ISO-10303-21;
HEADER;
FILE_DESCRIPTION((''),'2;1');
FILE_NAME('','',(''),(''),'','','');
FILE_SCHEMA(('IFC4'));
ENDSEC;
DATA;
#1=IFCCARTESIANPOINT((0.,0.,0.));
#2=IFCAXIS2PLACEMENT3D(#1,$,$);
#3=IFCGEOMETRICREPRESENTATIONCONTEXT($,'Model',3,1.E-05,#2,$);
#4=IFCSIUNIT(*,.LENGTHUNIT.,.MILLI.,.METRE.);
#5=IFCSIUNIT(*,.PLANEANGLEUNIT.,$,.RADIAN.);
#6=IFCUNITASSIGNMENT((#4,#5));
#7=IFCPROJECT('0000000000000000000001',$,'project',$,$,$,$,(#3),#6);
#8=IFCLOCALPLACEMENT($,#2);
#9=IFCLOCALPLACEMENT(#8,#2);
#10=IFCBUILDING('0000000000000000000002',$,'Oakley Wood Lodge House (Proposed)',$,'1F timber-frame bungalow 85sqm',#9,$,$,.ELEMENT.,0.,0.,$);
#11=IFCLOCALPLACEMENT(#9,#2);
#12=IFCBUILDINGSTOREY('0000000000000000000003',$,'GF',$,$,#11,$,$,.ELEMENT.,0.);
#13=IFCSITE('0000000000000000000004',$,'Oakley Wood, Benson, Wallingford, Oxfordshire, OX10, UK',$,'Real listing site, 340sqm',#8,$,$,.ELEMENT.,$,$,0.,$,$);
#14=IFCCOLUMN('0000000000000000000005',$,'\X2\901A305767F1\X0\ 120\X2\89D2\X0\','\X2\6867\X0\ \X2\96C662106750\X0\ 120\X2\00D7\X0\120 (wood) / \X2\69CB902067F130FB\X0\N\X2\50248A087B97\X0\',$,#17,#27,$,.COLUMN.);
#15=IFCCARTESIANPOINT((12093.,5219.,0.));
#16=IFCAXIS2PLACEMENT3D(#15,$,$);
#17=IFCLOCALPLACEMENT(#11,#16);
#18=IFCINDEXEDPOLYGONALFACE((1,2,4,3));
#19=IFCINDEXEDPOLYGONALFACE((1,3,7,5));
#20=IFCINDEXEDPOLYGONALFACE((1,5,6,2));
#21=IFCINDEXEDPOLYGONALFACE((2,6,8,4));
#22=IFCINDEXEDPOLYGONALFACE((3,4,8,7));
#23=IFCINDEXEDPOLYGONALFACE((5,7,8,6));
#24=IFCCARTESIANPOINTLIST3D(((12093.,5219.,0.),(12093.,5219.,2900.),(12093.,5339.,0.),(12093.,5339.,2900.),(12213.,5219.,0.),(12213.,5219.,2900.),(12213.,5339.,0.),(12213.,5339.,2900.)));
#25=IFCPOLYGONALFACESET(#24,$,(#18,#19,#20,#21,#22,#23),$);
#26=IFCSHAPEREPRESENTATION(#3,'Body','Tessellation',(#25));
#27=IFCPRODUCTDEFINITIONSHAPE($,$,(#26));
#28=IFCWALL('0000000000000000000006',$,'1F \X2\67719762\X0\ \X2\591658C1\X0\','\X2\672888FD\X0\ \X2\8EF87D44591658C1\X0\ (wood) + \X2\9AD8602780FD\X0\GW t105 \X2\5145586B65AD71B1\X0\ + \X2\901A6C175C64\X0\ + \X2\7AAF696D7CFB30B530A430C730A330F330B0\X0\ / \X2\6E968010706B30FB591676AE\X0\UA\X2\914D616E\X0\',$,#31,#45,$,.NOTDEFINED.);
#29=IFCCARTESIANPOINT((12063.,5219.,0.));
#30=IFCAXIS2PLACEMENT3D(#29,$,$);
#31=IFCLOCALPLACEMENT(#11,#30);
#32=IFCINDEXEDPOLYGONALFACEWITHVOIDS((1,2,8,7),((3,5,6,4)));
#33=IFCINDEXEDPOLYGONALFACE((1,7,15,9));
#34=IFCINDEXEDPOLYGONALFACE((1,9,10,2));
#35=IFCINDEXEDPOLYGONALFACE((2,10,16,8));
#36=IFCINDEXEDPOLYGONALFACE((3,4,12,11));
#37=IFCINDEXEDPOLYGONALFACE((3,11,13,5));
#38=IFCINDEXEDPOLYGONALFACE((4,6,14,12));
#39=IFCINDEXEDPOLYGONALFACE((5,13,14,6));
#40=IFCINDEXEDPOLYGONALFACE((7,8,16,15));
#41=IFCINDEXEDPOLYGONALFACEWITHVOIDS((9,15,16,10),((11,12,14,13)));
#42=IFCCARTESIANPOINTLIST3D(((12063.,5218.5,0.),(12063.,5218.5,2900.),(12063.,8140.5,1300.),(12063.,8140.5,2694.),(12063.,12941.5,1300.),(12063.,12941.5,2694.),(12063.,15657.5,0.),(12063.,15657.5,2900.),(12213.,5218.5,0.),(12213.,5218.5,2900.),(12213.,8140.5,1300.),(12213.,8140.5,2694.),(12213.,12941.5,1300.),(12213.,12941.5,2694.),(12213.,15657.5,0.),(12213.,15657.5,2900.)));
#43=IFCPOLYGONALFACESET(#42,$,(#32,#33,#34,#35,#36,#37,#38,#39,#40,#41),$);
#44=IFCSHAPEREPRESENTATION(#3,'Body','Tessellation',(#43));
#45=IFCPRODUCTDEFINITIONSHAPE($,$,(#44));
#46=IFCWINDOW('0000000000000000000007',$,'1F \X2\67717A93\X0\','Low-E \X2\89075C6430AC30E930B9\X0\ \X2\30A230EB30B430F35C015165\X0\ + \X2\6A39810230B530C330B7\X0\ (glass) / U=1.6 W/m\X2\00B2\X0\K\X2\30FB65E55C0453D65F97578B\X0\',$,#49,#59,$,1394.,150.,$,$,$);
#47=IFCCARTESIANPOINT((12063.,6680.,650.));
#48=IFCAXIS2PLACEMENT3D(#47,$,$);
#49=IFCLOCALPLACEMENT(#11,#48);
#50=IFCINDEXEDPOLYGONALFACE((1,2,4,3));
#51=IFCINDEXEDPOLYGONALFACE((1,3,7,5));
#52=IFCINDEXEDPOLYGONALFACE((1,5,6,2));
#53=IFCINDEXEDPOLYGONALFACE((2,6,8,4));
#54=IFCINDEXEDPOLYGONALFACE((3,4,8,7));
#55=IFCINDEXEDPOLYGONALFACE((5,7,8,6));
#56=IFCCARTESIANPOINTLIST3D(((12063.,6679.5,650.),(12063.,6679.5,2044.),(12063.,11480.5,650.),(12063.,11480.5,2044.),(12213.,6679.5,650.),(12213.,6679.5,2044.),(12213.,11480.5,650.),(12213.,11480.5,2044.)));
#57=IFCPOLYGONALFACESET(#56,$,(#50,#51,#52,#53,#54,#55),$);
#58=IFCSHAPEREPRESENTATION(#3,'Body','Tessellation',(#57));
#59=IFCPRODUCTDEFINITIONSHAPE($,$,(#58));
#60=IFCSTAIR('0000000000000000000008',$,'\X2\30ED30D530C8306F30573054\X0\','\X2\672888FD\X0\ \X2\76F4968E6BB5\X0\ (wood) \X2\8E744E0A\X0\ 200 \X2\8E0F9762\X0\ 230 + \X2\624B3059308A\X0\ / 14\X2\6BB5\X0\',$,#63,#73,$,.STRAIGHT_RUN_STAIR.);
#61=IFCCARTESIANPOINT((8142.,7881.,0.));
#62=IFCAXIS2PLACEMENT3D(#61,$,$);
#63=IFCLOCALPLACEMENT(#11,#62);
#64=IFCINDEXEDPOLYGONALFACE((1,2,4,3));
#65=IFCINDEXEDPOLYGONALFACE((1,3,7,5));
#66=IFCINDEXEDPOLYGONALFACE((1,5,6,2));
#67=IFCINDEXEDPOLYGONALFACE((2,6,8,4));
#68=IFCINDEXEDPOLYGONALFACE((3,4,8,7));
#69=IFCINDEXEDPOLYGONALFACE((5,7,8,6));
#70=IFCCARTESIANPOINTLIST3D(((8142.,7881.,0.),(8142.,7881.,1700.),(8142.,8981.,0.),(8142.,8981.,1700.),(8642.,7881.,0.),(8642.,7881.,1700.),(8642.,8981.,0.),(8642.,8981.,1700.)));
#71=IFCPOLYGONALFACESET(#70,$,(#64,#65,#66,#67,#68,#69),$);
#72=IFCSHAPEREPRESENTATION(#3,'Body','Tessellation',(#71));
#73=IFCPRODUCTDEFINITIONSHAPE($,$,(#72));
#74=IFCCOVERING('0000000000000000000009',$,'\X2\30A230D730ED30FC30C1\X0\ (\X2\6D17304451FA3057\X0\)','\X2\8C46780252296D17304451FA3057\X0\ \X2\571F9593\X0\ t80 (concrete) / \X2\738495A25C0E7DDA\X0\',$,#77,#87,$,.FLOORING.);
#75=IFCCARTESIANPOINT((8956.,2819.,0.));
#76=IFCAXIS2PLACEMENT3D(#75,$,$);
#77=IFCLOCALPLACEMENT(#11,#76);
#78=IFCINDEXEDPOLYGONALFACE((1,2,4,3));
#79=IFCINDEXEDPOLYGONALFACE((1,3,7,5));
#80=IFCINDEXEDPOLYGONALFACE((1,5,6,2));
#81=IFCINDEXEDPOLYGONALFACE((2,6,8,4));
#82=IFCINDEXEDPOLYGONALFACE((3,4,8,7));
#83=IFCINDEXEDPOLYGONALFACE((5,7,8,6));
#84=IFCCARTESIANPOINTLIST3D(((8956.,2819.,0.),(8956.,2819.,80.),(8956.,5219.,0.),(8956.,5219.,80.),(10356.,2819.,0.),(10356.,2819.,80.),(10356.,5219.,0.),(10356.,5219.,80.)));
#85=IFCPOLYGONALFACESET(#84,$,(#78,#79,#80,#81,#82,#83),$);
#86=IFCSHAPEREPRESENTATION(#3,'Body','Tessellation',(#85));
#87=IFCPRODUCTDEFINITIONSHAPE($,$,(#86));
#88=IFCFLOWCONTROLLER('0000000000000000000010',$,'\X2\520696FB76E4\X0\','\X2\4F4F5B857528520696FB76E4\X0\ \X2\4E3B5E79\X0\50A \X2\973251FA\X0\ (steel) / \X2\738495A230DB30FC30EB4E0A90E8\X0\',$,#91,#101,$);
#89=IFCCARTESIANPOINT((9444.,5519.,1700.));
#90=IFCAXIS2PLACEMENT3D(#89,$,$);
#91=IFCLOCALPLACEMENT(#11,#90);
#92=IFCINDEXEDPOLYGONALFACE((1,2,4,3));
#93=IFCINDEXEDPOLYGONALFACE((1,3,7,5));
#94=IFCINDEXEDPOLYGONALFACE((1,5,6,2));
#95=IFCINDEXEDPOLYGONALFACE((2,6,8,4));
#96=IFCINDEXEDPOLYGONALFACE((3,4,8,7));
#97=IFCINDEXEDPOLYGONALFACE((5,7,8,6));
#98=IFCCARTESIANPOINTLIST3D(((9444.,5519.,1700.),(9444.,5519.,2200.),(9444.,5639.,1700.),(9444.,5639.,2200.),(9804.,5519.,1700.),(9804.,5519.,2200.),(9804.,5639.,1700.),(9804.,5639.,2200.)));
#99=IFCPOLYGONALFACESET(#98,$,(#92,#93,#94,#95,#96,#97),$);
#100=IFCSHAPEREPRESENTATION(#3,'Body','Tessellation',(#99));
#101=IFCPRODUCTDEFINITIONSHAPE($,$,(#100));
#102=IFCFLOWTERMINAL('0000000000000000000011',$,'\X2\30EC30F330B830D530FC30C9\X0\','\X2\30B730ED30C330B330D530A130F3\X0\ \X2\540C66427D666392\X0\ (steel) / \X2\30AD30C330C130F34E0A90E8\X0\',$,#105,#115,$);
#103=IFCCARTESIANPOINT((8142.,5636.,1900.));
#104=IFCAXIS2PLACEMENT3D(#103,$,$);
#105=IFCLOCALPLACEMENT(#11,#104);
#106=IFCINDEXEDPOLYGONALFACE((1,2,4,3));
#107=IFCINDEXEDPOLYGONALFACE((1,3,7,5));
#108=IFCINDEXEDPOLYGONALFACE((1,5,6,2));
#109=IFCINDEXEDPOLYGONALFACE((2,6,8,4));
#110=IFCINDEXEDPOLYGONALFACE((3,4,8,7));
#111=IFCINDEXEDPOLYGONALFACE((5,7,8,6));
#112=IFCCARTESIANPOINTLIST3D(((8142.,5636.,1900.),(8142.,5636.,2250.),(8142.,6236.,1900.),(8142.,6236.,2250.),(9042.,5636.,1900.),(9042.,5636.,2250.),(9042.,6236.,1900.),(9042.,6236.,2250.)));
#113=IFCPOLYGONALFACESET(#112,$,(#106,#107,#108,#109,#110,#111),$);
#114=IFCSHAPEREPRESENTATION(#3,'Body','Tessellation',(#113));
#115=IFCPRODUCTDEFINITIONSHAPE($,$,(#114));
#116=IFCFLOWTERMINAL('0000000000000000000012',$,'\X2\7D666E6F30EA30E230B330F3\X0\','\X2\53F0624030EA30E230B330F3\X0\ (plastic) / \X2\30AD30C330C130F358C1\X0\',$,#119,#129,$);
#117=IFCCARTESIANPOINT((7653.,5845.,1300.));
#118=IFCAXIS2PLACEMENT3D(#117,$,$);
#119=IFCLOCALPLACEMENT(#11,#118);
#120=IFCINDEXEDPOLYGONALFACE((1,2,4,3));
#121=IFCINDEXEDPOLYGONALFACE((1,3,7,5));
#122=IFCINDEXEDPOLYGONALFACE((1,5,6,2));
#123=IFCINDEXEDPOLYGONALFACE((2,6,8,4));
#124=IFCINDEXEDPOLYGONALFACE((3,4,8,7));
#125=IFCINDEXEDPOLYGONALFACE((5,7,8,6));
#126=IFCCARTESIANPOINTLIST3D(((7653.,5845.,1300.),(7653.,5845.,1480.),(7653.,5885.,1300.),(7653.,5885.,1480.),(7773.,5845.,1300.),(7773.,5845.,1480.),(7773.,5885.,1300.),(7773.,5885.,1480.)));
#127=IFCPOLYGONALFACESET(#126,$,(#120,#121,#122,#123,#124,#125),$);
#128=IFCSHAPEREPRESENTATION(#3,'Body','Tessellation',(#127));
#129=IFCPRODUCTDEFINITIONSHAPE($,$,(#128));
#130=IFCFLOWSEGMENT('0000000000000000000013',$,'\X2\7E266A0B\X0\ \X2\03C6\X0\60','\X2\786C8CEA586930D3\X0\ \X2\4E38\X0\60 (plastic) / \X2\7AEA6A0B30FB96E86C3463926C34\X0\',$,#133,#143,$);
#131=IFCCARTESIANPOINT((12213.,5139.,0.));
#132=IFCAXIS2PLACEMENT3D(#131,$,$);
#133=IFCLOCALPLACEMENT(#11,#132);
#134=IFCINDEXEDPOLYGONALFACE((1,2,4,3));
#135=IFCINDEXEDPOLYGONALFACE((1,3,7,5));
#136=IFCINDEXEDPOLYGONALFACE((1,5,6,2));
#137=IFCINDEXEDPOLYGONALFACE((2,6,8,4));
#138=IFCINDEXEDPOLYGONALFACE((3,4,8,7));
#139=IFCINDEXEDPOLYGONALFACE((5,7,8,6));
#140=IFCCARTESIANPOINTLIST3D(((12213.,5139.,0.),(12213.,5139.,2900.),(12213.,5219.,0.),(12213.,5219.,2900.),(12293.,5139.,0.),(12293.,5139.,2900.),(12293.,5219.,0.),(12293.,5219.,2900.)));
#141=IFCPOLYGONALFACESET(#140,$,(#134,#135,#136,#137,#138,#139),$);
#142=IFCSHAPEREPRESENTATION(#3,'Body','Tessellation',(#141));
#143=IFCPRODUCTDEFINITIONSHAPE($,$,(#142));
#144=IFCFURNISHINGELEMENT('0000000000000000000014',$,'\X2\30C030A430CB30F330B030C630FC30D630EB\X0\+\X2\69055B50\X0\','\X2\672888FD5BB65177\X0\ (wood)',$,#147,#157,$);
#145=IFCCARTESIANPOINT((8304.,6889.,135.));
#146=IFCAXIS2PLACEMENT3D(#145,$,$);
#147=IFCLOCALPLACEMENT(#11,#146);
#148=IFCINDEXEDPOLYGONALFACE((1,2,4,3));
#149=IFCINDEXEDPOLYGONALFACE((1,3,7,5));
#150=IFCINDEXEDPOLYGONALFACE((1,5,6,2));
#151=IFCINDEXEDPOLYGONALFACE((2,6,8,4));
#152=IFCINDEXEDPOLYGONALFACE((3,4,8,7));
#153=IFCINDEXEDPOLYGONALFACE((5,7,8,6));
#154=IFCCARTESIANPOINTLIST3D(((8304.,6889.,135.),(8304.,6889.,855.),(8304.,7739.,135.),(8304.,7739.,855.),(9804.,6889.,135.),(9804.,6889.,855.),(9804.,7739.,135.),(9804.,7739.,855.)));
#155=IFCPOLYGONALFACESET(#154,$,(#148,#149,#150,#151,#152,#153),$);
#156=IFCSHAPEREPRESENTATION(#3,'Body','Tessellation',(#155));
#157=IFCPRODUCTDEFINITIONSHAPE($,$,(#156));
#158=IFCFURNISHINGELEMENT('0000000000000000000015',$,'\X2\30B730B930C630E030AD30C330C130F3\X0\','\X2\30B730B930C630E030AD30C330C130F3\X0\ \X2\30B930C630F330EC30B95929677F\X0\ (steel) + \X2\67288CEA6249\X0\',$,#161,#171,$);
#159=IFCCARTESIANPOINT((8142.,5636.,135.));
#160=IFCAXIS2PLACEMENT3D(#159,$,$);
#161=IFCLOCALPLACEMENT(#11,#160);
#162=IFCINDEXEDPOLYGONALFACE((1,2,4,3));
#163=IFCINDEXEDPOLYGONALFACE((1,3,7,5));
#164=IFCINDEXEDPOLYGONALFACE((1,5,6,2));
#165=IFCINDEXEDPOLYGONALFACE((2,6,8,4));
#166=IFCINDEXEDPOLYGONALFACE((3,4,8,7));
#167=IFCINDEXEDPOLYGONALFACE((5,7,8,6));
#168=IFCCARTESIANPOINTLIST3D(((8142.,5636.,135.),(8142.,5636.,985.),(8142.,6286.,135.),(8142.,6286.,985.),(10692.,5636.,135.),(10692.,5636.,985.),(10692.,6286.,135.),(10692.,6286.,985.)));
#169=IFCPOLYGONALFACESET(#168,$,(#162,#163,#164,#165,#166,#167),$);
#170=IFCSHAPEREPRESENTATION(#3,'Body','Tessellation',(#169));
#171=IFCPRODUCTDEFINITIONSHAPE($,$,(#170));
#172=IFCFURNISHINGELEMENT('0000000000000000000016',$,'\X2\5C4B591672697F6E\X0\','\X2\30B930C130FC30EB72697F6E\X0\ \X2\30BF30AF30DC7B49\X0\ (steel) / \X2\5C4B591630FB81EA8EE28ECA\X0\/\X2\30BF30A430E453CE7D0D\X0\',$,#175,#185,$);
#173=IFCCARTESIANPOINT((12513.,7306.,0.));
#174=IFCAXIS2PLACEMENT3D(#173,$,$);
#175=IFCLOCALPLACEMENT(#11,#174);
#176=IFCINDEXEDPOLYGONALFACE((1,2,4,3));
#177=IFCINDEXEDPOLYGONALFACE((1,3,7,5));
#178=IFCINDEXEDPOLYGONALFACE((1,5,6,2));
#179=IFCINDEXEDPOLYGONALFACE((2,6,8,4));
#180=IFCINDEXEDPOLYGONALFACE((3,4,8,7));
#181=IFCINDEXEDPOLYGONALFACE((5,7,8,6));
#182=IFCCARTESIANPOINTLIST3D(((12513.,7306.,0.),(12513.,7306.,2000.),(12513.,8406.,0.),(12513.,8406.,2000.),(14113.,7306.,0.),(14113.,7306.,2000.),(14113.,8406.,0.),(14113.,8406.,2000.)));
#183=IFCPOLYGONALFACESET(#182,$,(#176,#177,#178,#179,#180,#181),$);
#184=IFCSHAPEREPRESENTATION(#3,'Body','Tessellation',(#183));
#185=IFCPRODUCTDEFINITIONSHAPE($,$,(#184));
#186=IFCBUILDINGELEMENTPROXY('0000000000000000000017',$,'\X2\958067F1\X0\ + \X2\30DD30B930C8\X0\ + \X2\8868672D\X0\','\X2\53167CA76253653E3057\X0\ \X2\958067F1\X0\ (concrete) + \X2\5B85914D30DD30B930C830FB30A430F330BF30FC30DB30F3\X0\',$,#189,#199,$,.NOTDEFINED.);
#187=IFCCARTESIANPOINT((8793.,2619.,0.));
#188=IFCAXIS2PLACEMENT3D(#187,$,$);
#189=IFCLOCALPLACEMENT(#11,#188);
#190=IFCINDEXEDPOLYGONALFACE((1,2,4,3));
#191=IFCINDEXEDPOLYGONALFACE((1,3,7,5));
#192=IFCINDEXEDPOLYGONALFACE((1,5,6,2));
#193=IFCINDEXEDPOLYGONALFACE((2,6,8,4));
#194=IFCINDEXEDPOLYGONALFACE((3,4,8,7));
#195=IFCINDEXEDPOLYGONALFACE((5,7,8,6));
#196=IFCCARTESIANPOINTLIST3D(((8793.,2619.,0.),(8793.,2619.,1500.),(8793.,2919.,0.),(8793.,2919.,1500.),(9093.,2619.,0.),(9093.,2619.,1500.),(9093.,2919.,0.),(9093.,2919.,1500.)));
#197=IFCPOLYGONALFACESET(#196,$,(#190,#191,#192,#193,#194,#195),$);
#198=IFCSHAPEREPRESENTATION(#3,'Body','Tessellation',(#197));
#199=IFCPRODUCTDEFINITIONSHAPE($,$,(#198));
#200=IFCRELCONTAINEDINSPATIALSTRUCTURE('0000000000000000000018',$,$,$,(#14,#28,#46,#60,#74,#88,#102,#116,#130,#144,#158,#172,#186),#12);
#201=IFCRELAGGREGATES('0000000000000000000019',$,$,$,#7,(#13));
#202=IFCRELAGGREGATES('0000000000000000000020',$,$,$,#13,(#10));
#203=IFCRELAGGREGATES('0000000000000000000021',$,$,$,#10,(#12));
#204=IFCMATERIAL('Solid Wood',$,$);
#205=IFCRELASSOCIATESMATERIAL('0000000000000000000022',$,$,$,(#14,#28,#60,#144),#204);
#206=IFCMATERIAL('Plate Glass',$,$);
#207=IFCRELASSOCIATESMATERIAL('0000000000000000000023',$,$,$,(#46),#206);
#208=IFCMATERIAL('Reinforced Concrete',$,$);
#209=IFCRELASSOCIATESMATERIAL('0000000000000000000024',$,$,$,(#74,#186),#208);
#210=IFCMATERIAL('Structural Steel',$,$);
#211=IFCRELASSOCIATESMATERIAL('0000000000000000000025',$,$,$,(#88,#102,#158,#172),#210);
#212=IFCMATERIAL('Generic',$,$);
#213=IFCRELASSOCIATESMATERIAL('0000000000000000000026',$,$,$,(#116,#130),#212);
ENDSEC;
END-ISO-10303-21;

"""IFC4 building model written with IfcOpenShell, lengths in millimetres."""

from ifc_helpers import new_model, si_unit, frame, frame_2d, origin, place, context, project, spatial, rectangle, extrude, material, element, fill, save


model = new_model("IFC4")

# Units and contexts
model_context = context("Model", 3, precision=1e-05, world=origin())
ifc_project = project(units=[si_unit("LENGTHUNIT", "METRE", prefix="MILLI"), si_unit("PLANEANGLEUNIT", "RADIAN")], contexts=[model_context])

# Site, building, storey
site_placement = place(None, origin())
site = spatial("IfcSite", under=ifc_project, at=site_placement, Name="Oakley Wood, Benson, Wallingford, Oxfordshire, OX10, UK", ObjectType="Real listing site, 340sqm", CompositionType="ELEMENT", RefElevation=0.0)
building_placement = place(site_placement, origin())
building = spatial("IfcBuilding", under=site, at=building_placement, Name="Oakley Wood Lodge House (Proposed)", ObjectType="1F timber-frame bungalow 85sqm", CompositionType="ELEMENT", ElevationOfRefHeight=0.0, ElevationOfTerrain=0.0)
storey_placement = place(building_placement, origin())
storey = spatial("IfcBuildingStorey", under=building, at=storey_placement, Name="GF", CompositionType="ELEMENT", Elevation=0.0)

# Column
ifc_material_1 = material(Name="Solid Wood")
column_1_placement = place(storey_placement, frame((12093.0, 5219.0, 0.0)))
element("IfcColumn", 1, at=column_1_placement, inside=storey, material=ifc_material_1, Name="通し柱 120角", Description="桧 集成材 120×120 (wood) / 構造柱・N値計算", PredefinedType="COLUMN", context=model_context, shape_type="SweptSolid", body=[
    extrude(rectangle(XDim=120.0, YDim=120.0, at=frame_2d((60.0, 60.0))), frame((12093.0, 5219.0, 0.0)), (0.0, 0.0, 1.0), 2900.0),
])

# Wall, opening, window
wall_1_placement = place(storey_placement, frame((12063.0, 5219.0, 0.0)))
wall_1 = element("IfcWall", 2, at=wall_1_placement, inside=storey, material=ifc_material_1, Name="1F 東面 外壁", Description="木製 軸組外壁 (wood) + 高性能GW t105 充填断熱 + 通気層 + 窯業系サイディング / 準耐火・外皮UA配慮", PredefinedType="NOTDEFINED", context=model_context, shape_type="SweptSolid", body=[
    extrude(rectangle(XDim=150.0, YDim=10439.0, at=frame_2d((75.0, 5219.0))), frame((12063.0, 5219.0, 0.0)), (0.0, 0.0, 1.0), 2900.0),
])
opening_placement = place(storey_placement, frame((12063.0, 6680.0, 650.0)))
opening = element("IfcOpeningElement", 3, at=opening_placement, cuts=wall_1, PredefinedType="NOTDEFINED", context=model_context, shape_type="SweptSolid", body=[
    extrude(rectangle(XDim=150.0, YDim=4801.0, at=frame_2d((75.0, 2400.0))), frame((12063.0, 6680.0, 650.0)), (0.0, 0.0, 1.0), 1394.0),
])
ifc_material_2 = material(Name="Plate Glass")
window_placement = place(storey_placement, frame((12063.0, 6680.0, 650.0)))
window = element("IfcWindow", 4, at=window_placement, inside=storey, material=ifc_material_2, Name="1F 東窓", Description="Low-E 複層ガラス アルゴン封入 + 樹脂サッシ (glass) / U=1.6 W/m²K・日射取得型", OverallHeight=1394.0, OverallWidth=150.0, context=model_context, shape_type="SweptSolid", body=[
    extrude(rectangle(XDim=150.0, YDim=4801.0, at=frame_2d((75.0, 2400.0))), frame((12063.0, 6680.0, 650.0)), (0.0, 0.0, 1.0), 1394.0),
])
fill(opening, window)

# Stair
stair_placement = place(storey_placement, frame((8142.0, 7881.0, 0.0)))
element("IfcStair", 5, at=stair_placement, inside=storey, material=ifc_material_1, Name="ロフトはしご", Description="木製 直階段 (wood) 蹴上 200 踏面 230 + 手すり / 14段", PredefinedType="STRAIGHT_RUN_STAIR", context=model_context, shape_type="SweptSolid", body=[
    extrude(rectangle(XDim=500.0, YDim=1100.0, at=frame_2d((250.0, 550.0))), frame((8142.0, 7881.0, 0.0)), (0.0, 0.0, 1.0), 1700.0),
])

# Covering
ifc_material_3 = material(Name="Reinforced Concrete")
covering_placement = place(storey_placement, frame((8956.0, 2819.0, 0.0)))
element("IfcCovering", 6, at=covering_placement, inside=storey, material=ifc_material_3, Name="アプローチ (洗い出し)", Description="豆砂利洗い出し 土間 t80 (concrete) / 玄関導線", PredefinedType="FLOORING", context=model_context, shape_type="SweptSolid", body=[
    extrude(rectangle(XDim=1400.0, YDim=2400.0, at=frame_2d((700.0, 1200.0))), frame((8956.0, 2819.0, 0.0)), (0.0, 0.0, 1.0), 80.0),
])

# Flow controller
ifc_material_4 = material(Name="Structural Steel")
flow_controller_placement = place(storey_placement, frame((9444.0, 5519.0, 1700.0)))
element("IfcFlowController", 7, at=flow_controller_placement, inside=storey, material=ifc_material_4, Name="分電盤", Description="住宅用分電盤 主幹50A 露出 (steel) / 玄関ホール上部", context=model_context, shape_type="SweptSolid", body=[
    extrude(rectangle(XDim=360.0, YDim=120.0, at=frame_2d((180.0, 60.0))), frame((9444.0, 5519.0, 1700.0)), (0.0, 0.0, 1.0), 500.0),
])

# Flow terminals
flow_terminal_1_placement = place(storey_placement, frame((8142.0, 5636.0, 1900.0)))
element("IfcFlowTerminal", 8, at=flow_terminal_1_placement, inside=storey, material=ifc_material_4, Name="レンジフード", Description="シロッコファン 同時給排 (steel) / キッチン上部", context=model_context, shape_type="SweptSolid", body=[
    extrude(rectangle(XDim=900.0, YDim=600.0, at=frame_2d((450.0, 300.0))), frame((8142.0, 5636.0, 1900.0)), (0.0, 0.0, 1.0), 350.0),
])
ifc_material_5 = material(Name="Generic")
flow_terminal_2_placement = place(storey_placement, frame((7653.0, 5845.0, 1300.0)))
element("IfcFlowTerminal", 9, at=flow_terminal_2_placement, inside=storey, material=ifc_material_5, Name="給湯リモコン", Description="台所リモコン (plastic) / キッチン壁", context=model_context, shape_type="SweptSolid", body=[
    extrude(rectangle(XDim=120.0, YDim=40.0, at=frame_2d((60.0, 20.0))), frame((7653.0, 5845.0, 1300.0)), (0.0, 0.0, 1.0), 180.0),
])

# Flow segment
flow_segment_placement = place(storey_placement, frame((12213.0, 5139.0, 0.0)))
element("IfcFlowSegment", 10, at=flow_segment_placement, inside=storey, material=ifc_material_5, Name="縦樋 φ60", Description="硬質塩ビ 丸60 (plastic) / 竪樋・雨水排水", context=model_context, shape_type="SweptSolid", body=[
    extrude(rectangle(XDim=80.0, YDim=80.0, at=frame_2d((40.0, 40.0))), frame((12213.0, 5139.0, 0.0)), (0.0, 0.0, 1.0), 2900.0),
])

# Furnishing elements
furnishing_1_placement = place(storey_placement, frame((8304.0, 6889.0, 135.0)))
element("IfcFurnishingElement", 11, at=furnishing_1_placement, inside=storey, material=ifc_material_1, Name="ダイニングテーブル+椅子", Description="木製家具 (wood)", context=model_context, shape_type="SweptSolid", body=[
    extrude(rectangle(XDim=1500.0, YDim=850.0, at=frame_2d((750.0, 425.0))), frame((8304.0, 6889.0, 135.0)), (0.0, 0.0, 1.0), 720.0),
])
furnishing_2_placement = place(storey_placement, frame((8142.0, 5636.0, 135.0)))
element("IfcFurnishingElement", 12, at=furnishing_2_placement, inside=storey, material=ifc_material_4, Name="システムキッチン", Description="システムキッチン ステンレス天板 (steel) + 木質扉", context=model_context, shape_type="SweptSolid", body=[
    extrude(rectangle(XDim=2550.0, YDim=650.0, at=frame_2d((1275.0, 325.0))), frame((8142.0, 5636.0, 135.0)), (0.0, 0.0, 1.0), 850.0),
])
furnishing_3_placement = place(storey_placement, frame((12513.0, 7306.0, 0.0)))
element("IfcFurnishingElement", 13, at=furnishing_3_placement, inside=storey, material=ifc_material_4, Name="屋外物置", Description="スチール物置 タクボ等 (steel) / 屋外・自転車/タイヤ収納", context=model_context, shape_type="SweptSolid", body=[
    extrude(rectangle(XDim=1600.0, YDim=1100.0, at=frame_2d((800.0, 550.0))), frame((12513.0, 7306.0, 0.0)), (0.0, 0.0, 1.0), 2000.0),
])

# Building element proxy
proxy_placement = place(storey_placement, frame((8793.0, 2619.0, 0.0)))
element("IfcBuildingElementProxy", 14, at=proxy_placement, inside=storey, material=ifc_material_3, Name="門柱 + ポスト + 表札", Description="化粧打放し 門柱 (concrete) + 宅配ポスト・インターホン", PredefinedType="NOTDEFINED", context=model_context, shape_type="SweptSolid", body=[
    extrude(rectangle(XDim=300.0, YDim=300.0, at=frame_2d((150.0, 150.0))), frame((8793.0, 2619.0, 0.0)), (0.0, 0.0, 1.0), 1500.0),
])

save(model, "model.ifc")
